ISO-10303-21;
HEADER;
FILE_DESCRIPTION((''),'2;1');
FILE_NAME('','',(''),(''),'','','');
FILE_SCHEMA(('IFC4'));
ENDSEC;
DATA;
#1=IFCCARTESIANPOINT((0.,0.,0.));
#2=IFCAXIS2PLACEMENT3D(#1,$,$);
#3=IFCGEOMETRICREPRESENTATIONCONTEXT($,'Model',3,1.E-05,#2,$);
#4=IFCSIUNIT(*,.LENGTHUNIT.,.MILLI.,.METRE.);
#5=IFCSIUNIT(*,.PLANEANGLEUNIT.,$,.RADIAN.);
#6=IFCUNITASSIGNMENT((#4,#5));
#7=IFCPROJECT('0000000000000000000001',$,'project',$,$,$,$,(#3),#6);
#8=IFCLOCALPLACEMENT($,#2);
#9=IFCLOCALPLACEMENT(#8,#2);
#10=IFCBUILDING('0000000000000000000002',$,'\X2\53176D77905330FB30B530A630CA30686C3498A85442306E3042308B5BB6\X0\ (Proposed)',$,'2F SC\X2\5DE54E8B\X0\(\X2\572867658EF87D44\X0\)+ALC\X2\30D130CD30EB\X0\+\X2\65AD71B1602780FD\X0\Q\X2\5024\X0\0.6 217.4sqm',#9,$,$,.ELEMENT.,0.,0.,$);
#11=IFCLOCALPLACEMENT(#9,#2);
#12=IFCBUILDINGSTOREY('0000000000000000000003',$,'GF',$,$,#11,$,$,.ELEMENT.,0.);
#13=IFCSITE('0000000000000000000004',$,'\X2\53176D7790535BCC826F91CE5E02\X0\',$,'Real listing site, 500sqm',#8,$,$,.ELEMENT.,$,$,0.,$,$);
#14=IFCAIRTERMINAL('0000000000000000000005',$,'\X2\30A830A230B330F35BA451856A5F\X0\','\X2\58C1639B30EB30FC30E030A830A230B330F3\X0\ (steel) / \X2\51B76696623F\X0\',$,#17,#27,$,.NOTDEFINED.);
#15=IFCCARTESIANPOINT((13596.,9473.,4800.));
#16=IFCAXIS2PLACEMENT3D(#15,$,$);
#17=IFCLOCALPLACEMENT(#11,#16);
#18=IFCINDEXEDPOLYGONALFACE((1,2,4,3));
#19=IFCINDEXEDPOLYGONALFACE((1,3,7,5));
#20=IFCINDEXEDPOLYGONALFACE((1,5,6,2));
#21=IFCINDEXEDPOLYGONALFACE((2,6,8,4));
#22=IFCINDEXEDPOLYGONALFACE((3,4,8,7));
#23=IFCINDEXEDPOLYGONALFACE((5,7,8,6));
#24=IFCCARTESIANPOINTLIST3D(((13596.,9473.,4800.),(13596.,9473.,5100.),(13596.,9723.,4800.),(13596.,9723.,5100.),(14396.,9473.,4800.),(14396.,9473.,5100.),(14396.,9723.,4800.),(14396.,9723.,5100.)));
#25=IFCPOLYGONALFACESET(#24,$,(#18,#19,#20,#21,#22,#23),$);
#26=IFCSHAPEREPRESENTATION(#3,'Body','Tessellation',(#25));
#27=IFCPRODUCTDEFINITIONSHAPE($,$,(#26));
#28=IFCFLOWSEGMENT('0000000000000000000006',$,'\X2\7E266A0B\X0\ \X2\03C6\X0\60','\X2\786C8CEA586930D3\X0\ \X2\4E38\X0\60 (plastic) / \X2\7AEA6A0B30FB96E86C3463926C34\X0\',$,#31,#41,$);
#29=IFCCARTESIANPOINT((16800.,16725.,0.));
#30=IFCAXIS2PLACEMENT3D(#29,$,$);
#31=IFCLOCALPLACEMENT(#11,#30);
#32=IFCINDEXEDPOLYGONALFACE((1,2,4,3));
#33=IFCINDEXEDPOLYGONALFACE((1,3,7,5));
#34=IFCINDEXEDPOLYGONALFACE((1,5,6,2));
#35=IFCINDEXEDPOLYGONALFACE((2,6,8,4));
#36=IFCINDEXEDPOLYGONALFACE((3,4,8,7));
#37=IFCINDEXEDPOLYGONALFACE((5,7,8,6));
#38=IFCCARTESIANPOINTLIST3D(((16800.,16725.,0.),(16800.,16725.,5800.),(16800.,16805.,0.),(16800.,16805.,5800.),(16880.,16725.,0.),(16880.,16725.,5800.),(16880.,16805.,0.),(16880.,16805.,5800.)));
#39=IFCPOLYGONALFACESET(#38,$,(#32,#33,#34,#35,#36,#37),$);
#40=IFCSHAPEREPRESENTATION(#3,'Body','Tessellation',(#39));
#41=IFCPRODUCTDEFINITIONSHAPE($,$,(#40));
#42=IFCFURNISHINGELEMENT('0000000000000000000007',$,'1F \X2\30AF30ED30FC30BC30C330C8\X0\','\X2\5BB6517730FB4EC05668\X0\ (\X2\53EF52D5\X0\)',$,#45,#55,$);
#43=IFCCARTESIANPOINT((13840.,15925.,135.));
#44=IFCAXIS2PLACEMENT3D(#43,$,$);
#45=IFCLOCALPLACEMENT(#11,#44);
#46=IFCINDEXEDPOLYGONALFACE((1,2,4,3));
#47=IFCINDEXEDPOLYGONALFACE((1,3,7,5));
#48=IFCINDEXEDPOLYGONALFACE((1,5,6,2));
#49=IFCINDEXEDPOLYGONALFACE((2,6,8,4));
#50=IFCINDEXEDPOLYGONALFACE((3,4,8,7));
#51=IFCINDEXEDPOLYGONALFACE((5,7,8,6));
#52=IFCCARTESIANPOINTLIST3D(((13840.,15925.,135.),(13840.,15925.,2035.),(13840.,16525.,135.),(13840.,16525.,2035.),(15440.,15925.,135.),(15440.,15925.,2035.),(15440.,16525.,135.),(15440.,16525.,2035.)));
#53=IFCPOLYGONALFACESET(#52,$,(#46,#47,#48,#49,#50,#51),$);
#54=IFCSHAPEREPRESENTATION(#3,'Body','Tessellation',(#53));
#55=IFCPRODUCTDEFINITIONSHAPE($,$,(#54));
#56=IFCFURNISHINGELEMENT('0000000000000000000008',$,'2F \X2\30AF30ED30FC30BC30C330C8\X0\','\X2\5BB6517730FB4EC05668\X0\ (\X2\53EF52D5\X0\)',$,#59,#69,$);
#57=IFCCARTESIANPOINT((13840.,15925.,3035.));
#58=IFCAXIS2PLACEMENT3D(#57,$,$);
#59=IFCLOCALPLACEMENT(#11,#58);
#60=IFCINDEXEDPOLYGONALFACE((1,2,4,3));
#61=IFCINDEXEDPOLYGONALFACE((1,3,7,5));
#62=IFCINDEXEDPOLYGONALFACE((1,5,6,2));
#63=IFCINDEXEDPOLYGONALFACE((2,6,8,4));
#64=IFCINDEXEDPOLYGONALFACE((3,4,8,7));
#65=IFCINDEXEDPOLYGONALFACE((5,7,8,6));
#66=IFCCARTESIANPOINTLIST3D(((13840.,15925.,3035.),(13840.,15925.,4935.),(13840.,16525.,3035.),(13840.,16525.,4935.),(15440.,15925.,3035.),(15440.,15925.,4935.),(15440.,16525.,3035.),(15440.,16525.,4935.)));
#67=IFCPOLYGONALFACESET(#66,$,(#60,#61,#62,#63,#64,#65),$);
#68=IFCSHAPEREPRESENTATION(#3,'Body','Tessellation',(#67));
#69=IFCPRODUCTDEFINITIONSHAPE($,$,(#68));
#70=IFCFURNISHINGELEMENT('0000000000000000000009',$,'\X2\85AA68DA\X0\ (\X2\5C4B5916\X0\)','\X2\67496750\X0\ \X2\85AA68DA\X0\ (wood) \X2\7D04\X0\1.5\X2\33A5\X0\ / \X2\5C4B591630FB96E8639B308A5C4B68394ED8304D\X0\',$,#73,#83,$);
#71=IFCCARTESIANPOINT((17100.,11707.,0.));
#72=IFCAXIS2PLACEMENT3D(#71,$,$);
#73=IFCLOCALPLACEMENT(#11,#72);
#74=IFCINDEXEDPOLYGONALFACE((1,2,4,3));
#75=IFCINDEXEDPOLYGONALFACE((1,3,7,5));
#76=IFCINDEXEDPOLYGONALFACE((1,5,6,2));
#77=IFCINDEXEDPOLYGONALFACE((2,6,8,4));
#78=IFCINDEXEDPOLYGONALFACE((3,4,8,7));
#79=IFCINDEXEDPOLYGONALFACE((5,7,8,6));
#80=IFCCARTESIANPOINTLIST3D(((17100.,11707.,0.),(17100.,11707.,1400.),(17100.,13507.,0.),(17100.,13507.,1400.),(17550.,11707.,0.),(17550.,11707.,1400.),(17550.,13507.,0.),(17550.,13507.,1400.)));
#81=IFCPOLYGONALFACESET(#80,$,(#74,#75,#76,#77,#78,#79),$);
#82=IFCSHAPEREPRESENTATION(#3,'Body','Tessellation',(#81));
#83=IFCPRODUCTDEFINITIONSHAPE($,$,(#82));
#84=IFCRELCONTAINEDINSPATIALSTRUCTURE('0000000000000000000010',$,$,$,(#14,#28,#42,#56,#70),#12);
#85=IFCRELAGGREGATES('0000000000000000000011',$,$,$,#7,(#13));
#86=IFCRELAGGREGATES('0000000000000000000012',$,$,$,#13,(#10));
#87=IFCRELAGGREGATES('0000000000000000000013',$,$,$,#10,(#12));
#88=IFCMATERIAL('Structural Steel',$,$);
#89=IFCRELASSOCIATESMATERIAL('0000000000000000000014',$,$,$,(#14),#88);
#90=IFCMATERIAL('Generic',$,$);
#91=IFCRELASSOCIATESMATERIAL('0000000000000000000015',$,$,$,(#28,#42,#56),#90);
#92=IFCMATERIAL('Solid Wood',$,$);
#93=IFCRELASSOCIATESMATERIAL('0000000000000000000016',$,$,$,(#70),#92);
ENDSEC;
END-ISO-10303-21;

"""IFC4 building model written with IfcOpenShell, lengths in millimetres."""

from ifc_helpers import new_model, si_unit, frame, frame_2d, origin, place, context, project, spatial, rectangle, extrude, material, element, save


model = new_model("IFC4")

# Units and contexts
model_context = context("Model", 3, precision=1e-05, world=origin())
ifc_project = project(units=[si_unit("LENGTHUNIT", "METRE", prefix="MILLI"), si_unit("PLANEANGLEUNIT", "RADIAN")], contexts=[model_context])

# Site, building, storey
site_placement = place(None, origin())
site = spatial("IfcSite", under=ifc_project, at=site_placement, Name="北海道富良野市", ObjectType="Real listing site, 500sqm", CompositionType="ELEMENT", RefElevation=0.0)
building_placement = place(site_placement, origin())
building = spatial("IfcBuilding", under=site, at=building_placement, Name="北海道・サウナと水風呂のある家 (Proposed)", ObjectType="2F SC工事(在来軸組)+ALCパネル+断熱性能Q値0.6 217.4sqm", CompositionType="ELEMENT", ElevationOfRefHeight=0.0, ElevationOfTerrain=0.0)
storey_placement = place(building_placement, origin())
storey = spatial("IfcBuildingStorey", under=building, at=storey_placement, Name="GF", CompositionType="ELEMENT", Elevation=0.0)

# Shared definitions
ifc_material_1 = material(Name="Solid Wood")

# Shared definitions
ifc_material_2 = material(Name="Generic")

# Air terminal
ifc_material_3 = material(Name="Structural Steel")
air_terminal_placement = place(storey_placement, frame((13596.0, 9473.0, 4800.0)))
element("IfcAirTerminal", 1, at=air_terminal_placement, inside=storey, material=ifc_material_3, Name="エアコン室内機", Description="壁掛ルームエアコン (steel) / 冷暖房", PredefinedType="NOTDEFINED", context=model_context, shape_type="SweptSolid", body=[
    extrude(rectangle(XDim=800.0, YDim=250.0, at=frame_2d((400.0, 125.0))), frame((13596.0, 9473.0, 4800.0)), (0.0, 0.0, 1.0), 300.0),
])

# Flow segment
flow_segment_placement = place(storey_placement, frame((16800.0, 16725.0, 0.0)))
element("IfcFlowSegment", 2, at=flow_segment_placement, inside=storey, material=ifc_material_2, Name="縦樋 φ60", Description="硬質塩ビ 丸60 (plastic) / 竪樋・雨水排水", context=model_context, shape_type="SweptSolid", body=[
    extrude(rectangle(XDim=80.0, YDim=80.0, at=frame_2d((40.0, 40.0))), frame((16800.0, 16725.0, 0.0)), (0.0, 0.0, 1.0), 5800.0),
])

# Furnishing elements
furnishing_1_placement = place(storey_placement, frame((13840.0, 15925.0, 135.0)))
element("IfcFurnishingElement", 3, at=furnishing_1_placement, inside=storey, material=ifc_material_2, Name="1F クローゼット", Description="家具・什器 (可動)", context=model_context, shape_type="SweptSolid", body=[
    extrude(rectangle(XDim=1600.0, YDim=600.0, at=frame_2d((800.0, 300.0))), frame((13840.0, 15925.0, 135.0)), (0.0, 0.0, 1.0), 1900.0),
])
furnishing_2_placement = place(storey_placement, frame((13840.0, 15925.0, 3035.0)))
element("IfcFurnishingElement", 4, at=furnishing_2_placement, inside=storey, material=ifc_material_2, Name="2F クローゼット", Description="家具・什器 (可動)", context=model_context, shape_type="SweptSolid", body=[
    extrude(rectangle(XDim=1600.0, YDim=600.0, at=frame_2d((800.0, 300.0))), frame((13840.0, 15925.0, 3035.0)), (0.0, 0.0, 1.0), 1900.0),
])
furnishing_3_placement = place(storey_placement, frame((17100.0, 11707.0, 0.0)))
element("IfcFurnishingElement", 5, at=furnishing_3_placement, inside=storey, material=ifc_material_1, Name="薪棚 (屋外)", Description="杉材 薪棚 (wood) 約1.5㎥ / 屋外・雨掛り屋根付き", context=model_context, shape_type="SweptSolid", body=[
    extrude(rectangle(XDim=450.0, YDim=1800.0, at=frame_2d((225.0, 900.0))), frame((17100.0, 11707.0, 0.0)), (0.0, 0.0, 1.0), 1400.0),
])

save(model, "model.ifc")
